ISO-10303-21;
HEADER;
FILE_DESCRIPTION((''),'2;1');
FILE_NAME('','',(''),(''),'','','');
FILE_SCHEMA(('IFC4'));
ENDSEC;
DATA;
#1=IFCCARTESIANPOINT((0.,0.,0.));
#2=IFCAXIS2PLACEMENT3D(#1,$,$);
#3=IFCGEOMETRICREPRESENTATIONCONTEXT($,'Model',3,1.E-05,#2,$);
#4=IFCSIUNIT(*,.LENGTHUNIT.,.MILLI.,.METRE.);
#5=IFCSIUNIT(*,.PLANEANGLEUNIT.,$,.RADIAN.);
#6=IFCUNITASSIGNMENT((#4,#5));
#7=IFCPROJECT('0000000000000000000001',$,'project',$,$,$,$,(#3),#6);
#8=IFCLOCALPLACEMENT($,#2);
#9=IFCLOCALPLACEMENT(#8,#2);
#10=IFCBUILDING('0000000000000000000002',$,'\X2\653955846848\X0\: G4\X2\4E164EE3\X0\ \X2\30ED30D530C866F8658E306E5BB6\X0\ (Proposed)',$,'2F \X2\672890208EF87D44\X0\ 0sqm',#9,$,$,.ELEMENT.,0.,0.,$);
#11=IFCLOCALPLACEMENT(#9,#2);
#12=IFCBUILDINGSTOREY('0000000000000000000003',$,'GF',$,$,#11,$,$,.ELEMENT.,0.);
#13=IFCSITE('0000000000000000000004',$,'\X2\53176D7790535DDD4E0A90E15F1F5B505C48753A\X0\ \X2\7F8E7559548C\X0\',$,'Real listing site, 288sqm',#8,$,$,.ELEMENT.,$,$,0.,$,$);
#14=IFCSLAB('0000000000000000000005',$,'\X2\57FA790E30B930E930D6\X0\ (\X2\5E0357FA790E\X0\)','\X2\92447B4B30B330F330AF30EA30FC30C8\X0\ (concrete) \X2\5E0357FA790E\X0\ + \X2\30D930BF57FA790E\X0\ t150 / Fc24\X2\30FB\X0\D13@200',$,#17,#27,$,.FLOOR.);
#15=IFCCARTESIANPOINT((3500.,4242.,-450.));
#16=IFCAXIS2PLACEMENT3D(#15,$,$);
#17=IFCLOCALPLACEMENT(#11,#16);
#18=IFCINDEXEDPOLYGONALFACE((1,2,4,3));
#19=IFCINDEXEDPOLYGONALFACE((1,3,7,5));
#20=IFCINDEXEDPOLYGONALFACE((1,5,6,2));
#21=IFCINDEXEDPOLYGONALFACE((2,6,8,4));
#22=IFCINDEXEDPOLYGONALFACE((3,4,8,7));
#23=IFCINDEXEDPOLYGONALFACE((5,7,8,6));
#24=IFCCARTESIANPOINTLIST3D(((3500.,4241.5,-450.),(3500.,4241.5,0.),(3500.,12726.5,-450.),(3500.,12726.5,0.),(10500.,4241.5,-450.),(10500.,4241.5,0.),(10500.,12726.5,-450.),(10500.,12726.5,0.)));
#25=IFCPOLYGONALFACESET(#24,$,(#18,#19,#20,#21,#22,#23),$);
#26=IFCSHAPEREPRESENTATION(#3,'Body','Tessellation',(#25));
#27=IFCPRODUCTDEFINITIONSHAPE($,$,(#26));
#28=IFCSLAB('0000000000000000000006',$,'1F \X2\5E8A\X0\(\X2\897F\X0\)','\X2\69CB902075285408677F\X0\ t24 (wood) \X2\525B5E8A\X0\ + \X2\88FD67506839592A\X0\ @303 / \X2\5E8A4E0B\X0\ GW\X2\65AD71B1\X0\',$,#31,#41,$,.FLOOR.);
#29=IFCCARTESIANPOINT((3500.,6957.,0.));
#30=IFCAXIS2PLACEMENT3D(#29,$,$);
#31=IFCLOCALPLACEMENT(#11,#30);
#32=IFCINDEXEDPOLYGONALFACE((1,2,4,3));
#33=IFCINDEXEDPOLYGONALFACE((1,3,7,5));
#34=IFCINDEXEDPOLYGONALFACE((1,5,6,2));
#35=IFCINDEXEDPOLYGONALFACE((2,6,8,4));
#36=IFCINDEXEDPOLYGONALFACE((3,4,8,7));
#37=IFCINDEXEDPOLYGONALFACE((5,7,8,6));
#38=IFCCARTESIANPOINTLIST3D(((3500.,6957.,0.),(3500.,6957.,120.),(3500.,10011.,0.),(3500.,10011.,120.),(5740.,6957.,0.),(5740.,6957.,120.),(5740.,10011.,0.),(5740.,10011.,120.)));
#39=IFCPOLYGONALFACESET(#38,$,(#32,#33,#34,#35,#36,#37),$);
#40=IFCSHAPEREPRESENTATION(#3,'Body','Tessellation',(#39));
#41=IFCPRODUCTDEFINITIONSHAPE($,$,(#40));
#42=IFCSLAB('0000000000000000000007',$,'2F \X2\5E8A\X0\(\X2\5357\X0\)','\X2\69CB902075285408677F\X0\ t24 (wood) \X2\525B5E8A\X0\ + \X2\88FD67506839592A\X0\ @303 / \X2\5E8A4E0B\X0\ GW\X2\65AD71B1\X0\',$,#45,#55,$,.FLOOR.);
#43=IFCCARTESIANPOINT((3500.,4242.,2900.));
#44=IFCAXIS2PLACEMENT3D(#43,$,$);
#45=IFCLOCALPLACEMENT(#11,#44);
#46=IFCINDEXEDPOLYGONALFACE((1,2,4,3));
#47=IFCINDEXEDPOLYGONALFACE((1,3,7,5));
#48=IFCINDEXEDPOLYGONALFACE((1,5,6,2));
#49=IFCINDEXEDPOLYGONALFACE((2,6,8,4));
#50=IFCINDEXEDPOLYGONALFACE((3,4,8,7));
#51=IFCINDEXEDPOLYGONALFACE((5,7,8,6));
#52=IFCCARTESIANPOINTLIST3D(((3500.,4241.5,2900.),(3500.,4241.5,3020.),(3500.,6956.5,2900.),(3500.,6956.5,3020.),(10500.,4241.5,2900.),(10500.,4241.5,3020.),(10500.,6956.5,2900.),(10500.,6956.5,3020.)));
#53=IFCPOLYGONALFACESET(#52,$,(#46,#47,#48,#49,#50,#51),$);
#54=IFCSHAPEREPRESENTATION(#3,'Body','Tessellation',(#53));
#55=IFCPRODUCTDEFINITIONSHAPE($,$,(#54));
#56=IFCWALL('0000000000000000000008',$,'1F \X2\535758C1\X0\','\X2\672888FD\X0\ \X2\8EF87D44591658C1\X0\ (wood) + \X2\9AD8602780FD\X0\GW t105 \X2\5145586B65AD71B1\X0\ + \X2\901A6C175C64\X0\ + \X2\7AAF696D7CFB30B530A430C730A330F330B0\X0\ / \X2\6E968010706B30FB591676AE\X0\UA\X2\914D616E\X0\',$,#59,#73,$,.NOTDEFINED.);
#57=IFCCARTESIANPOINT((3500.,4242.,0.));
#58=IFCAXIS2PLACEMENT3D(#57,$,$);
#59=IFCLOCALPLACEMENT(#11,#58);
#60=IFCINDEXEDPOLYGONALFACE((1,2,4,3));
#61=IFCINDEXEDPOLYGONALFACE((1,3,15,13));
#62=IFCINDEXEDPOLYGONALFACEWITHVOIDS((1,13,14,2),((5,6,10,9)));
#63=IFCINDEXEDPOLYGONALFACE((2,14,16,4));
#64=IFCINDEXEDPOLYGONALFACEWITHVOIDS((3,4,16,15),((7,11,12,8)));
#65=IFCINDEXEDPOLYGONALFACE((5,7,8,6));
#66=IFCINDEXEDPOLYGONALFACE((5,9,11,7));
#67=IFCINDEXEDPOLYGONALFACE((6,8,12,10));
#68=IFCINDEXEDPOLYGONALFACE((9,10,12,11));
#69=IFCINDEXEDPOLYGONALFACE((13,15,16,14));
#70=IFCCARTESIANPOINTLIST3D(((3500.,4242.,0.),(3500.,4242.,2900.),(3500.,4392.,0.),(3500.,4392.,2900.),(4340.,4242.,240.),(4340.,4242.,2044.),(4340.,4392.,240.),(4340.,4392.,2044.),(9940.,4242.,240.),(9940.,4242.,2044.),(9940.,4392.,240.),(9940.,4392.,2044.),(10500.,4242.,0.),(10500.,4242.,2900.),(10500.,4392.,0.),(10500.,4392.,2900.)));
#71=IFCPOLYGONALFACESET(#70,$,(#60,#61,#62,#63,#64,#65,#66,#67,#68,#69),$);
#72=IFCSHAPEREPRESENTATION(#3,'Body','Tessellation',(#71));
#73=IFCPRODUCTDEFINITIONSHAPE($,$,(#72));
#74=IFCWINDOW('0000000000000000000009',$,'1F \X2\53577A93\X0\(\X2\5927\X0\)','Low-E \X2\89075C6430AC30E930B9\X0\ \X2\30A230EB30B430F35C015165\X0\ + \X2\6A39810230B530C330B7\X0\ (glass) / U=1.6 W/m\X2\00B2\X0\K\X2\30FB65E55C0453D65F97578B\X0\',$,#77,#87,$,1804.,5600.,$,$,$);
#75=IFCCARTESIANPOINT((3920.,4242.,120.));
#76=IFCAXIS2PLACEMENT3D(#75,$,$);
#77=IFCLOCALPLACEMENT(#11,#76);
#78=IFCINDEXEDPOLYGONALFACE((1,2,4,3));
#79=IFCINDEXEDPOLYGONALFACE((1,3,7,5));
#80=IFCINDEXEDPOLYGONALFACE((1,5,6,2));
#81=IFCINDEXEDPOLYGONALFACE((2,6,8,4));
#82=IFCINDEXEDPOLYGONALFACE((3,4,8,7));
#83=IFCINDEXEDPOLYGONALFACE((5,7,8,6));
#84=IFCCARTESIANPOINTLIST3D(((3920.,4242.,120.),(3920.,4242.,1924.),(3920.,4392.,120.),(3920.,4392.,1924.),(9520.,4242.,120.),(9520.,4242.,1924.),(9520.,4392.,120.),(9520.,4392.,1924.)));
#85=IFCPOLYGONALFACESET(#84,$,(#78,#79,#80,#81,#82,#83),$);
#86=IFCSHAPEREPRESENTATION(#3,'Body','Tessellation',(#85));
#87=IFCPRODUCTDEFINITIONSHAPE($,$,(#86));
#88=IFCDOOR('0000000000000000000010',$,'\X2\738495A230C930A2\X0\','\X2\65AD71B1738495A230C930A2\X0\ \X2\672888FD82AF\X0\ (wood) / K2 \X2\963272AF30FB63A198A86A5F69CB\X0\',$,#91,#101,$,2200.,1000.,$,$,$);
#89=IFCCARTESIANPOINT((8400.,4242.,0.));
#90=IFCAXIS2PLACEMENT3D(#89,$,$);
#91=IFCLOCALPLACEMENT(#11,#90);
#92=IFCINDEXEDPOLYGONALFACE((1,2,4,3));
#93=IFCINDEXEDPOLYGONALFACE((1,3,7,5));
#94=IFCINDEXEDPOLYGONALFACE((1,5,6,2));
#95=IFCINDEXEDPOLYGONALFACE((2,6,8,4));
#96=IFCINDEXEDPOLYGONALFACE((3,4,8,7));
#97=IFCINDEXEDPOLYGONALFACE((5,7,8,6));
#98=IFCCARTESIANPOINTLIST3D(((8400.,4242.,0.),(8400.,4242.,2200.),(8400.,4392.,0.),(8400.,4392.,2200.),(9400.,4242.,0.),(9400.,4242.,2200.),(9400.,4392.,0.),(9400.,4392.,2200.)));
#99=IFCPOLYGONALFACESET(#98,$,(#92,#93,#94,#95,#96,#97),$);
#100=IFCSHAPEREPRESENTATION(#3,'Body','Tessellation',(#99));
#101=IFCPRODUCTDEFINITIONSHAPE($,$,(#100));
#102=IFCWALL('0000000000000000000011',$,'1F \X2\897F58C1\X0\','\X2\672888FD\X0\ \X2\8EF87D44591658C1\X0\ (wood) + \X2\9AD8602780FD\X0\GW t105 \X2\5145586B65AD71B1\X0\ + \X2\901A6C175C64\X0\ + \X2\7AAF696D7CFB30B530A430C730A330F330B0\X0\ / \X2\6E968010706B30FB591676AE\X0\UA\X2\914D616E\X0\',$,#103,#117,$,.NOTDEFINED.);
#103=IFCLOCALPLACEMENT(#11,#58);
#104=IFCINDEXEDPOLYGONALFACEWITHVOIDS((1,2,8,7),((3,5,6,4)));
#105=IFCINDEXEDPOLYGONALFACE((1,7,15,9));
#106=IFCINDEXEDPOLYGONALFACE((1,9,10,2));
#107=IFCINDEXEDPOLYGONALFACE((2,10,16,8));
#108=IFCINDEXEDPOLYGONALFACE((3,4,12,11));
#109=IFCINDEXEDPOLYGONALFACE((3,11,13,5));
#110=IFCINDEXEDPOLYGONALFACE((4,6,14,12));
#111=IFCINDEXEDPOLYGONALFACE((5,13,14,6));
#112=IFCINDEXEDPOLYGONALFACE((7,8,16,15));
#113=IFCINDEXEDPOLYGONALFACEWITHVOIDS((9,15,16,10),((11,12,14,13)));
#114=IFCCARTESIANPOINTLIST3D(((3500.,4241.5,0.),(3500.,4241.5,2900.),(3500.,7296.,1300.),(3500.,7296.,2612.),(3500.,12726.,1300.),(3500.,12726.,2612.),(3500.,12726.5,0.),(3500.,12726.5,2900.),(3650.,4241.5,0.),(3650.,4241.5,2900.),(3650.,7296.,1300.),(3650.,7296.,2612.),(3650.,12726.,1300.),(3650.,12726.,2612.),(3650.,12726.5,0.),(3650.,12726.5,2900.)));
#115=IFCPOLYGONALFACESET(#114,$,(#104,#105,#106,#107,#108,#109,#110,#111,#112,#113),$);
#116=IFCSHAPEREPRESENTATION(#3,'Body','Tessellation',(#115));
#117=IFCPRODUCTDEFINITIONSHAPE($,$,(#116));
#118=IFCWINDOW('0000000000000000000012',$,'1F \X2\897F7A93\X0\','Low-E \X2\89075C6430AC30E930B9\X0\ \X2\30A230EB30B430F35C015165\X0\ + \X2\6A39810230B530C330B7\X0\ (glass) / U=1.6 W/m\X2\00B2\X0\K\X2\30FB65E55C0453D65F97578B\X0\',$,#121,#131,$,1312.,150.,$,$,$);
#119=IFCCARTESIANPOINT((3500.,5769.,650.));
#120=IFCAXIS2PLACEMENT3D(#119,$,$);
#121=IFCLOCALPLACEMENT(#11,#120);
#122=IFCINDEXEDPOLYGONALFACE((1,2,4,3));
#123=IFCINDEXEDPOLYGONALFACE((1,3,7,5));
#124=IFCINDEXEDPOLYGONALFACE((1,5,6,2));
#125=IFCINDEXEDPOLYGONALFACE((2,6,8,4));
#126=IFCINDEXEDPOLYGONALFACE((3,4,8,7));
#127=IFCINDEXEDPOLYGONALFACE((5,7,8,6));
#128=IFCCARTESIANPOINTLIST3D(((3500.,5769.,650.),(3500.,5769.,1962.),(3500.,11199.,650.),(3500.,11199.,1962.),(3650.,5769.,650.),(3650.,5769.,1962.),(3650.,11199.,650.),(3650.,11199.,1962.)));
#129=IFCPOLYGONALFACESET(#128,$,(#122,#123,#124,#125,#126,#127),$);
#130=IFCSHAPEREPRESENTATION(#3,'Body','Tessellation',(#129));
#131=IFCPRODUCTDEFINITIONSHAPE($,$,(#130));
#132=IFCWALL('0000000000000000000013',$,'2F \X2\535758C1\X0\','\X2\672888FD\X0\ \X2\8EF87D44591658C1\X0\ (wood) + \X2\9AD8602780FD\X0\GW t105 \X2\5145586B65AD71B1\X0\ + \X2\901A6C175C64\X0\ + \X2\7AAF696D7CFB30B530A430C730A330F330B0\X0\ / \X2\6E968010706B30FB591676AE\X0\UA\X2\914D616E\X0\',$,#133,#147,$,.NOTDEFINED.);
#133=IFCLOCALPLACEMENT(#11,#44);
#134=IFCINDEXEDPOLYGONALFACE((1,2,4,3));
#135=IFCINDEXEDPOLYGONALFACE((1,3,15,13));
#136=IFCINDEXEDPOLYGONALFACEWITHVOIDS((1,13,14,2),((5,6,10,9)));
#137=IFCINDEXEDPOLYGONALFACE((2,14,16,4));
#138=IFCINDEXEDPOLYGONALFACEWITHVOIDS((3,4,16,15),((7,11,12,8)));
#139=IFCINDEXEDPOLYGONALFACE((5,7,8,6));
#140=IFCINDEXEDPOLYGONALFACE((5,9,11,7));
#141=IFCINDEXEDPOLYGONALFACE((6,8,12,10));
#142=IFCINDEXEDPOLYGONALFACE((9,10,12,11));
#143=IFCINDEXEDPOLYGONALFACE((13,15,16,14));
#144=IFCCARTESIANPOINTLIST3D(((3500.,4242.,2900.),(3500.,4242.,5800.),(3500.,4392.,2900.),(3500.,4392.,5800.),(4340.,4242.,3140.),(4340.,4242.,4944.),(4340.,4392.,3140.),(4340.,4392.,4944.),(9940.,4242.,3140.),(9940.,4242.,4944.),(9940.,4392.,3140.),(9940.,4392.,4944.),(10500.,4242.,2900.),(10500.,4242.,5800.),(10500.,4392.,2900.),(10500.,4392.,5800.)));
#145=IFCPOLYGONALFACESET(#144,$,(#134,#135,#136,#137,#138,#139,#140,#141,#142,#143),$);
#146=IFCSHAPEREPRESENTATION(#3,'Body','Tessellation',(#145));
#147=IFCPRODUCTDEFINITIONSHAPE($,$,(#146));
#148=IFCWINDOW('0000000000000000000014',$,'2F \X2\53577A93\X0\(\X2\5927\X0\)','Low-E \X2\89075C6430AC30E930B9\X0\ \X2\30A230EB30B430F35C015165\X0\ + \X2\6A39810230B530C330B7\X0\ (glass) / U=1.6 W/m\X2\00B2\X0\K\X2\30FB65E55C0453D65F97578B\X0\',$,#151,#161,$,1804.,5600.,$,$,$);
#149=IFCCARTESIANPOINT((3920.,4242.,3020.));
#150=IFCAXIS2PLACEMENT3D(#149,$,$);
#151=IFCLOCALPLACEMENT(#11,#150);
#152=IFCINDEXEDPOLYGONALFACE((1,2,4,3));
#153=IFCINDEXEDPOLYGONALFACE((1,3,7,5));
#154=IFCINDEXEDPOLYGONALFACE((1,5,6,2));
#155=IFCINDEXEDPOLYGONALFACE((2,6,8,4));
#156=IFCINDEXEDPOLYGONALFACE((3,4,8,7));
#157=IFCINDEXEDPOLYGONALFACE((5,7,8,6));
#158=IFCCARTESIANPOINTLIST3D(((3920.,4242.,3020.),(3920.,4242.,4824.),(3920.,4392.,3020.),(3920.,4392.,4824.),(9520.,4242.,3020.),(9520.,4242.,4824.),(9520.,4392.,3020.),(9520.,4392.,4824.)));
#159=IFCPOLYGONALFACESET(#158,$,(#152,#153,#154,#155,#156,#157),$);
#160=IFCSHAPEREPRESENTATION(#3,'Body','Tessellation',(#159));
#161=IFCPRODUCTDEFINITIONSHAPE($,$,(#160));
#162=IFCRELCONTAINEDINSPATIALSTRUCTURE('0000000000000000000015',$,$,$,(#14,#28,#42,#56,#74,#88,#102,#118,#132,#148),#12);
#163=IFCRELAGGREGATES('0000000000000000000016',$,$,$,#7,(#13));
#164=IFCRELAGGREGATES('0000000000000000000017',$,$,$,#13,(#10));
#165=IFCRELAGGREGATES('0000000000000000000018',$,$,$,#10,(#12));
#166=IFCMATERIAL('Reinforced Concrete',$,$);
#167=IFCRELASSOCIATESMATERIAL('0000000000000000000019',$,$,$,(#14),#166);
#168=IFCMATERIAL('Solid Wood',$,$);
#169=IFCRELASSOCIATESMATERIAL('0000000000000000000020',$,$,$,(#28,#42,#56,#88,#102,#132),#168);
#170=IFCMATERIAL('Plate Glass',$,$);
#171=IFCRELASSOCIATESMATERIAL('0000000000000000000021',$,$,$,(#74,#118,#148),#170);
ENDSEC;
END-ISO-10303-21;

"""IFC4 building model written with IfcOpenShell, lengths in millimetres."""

from ifc_helpers import new_model, si_unit, frame, frame_2d, origin, place, context, project, spatial, rectangle, extrude, material, element, fill, save


model = new_model("IFC4")

# Units and contexts
model_context = context("Model", 3, precision=1e-05, world=origin())
ifc_project = project(units=[si_unit("LENGTHUNIT", "METRE", prefix="MILLI"), si_unit("PLANEANGLEUNIT", "RADIAN")], contexts=[model_context])

# Site, building, storey
site_placement = place(None, origin())
site = spatial("IfcSite", under=ifc_project, at=site_placement, Name="北海道川上郡弟子屈町 美留和", ObjectType="Real listing site, 288sqm", CompositionType="ELEMENT", RefElevation=0.0)
building_placement = place(site_placement, origin())
building = spatial("IfcBuilding", under=site, at=building_placement, Name="改善案: G4世代 ロフト書斎の家 (Proposed)", ObjectType="2F 木造軸組 0sqm", CompositionType="ELEMENT", ElevationOfRefHeight=0.0, ElevationOfTerrain=0.0)
storey_placement = place(building_placement, origin())
storey = spatial("IfcBuildingStorey", under=building, at=storey_placement, Name="GF", CompositionType="ELEMENT", Elevation=0.0)

# Slabs
ifc_material_1 = material(Name="Reinforced Concrete")
slab_1_placement = place(storey_placement, frame((3500.0, 4242.0, -450.0)))
element("IfcSlab", 1, at=slab_1_placement, inside=storey, material=ifc_material_1, Name="基礎スラブ (布基礎)", Description="鉄筋コンクリート (concrete) 布基礎 + ベタ基礎 t150 / Fc24・D13@200", PredefinedType="FLOOR", context=model_context, shape_type="SweptSolid", body=[
    extrude(rectangle(XDim=7000.0, YDim=8485.0, at=frame_2d((3500.0, 4242.0))), frame((3500.0, 4242.0, -450.0)), (0.0, 0.0, 1.0), 450.0),
])
ifc_material_2 = material(Name="Solid Wood")
slab_2_placement = place(storey_placement, frame((3500.0, 6957.0, 0.0)))
element("IfcSlab", 2, at=slab_2_placement, inside=storey, material=ifc_material_2, Name="1F 床(西)", Description="構造用合板 t24 (wood) 剛床 + 製材根太 @303 / 床下 GW断熱", PredefinedType="FLOOR", context=model_context, shape_type="SweptSolid", body=[
    extrude(rectangle(XDim=2240.0, YDim=3054.0, at=frame_2d((1120.0, 1527.0))), frame((3500.0, 6957.0, 0.0)), (0.0, 0.0, 1.0), 120.0),
])
slab_3_placement = place(storey_placement, frame((3500.0, 4242.0, 2900.0)))
element("IfcSlab", 3, at=slab_3_placement, inside=storey, material=ifc_material_2, Name="2F 床(南)", Description="構造用合板 t24 (wood) 剛床 + 製材根太 @303 / 床下 GW断熱", PredefinedType="FLOOR", context=model_context, shape_type="SweptSolid", body=[
    extrude(rectangle(XDim=7000.0, YDim=2715.0, at=frame_2d((3500.0, 1357.0))), frame((3500.0, 4242.0, 2900.0)), (0.0, 0.0, 1.0), 120.0),
])

# Wall, openings, window, door
wall_1_placement = place(storey_placement, frame((3500.0, 4242.0, 0.0)))
wall_1 = element("IfcWall", 4, at=wall_1_placement, inside=storey, material=ifc_material_2, Name="1F 南壁", Description="木製 軸組外壁 (wood) + 高性能GW t105 充填断熱 + 通気層 + 窯業系サイディング / 準耐火・外皮UA配慮", PredefinedType="NOTDEFINED", context=model_context, shape_type="SweptSolid", body=[
    extrude(rectangle(XDim=7000.0, YDim=150.0, at=frame_2d((3500.0, 75.0))), frame((3500.0, 4242.0, 0.0)), (0.0, 0.0, 1.0), 2900.0),
])
opening_1_placement = place(storey_placement, frame((3920.0, 4242.0, 120.0)))
opening_1 = element("IfcOpeningElement", 5, at=opening_1_placement, cuts=wall_1, PredefinedType="NOTDEFINED", context=model_context, shape_type="SweptSolid", body=[
    extrude(rectangle(XDim=5600.0, YDim=150.0, at=frame_2d((2800.0, 75.0))), frame((3920.0, 4242.0, 120.0)), (0.0, 0.0, 1.0), 1804.0),
])
opening_2_placement = place(storey_placement, frame((8400.0, 4242.0, 0.0)))
opening_2 = element("IfcOpeningElement", 6, at=opening_2_placement, cuts=wall_1, PredefinedType="NOTDEFINED", context=model_context, shape_type="SweptSolid", body=[
    extrude(rectangle(XDim=1000.0, YDim=150.0, at=frame_2d((500.0, 75.0))), frame((8400.0, 4242.0, 0.0)), (0.0, 0.0, 1.0), 2200.0),
])
ifc_material_3 = material(Name="Plate Glass")
window_1_placement = place(storey_placement, frame((3920.0, 4242.0, 120.0)))
window_1 = element("IfcWindow", 7, at=window_1_placement, inside=storey, material=ifc_material_3, Name="1F 南窓(大)", Description="Low-E 複層ガラス アルゴン封入 + 樹脂サッシ (glass) / U=1.6 W/m²K・日射取得型", OverallHeight=1804.0, OverallWidth=5600.0, context=model_context, shape_type="SweptSolid", body=[
    extrude(rectangle(XDim=5600.0, YDim=150.0, at=frame_2d((2800.0, 75.0))), frame((3920.0, 4242.0, 120.0)), (0.0, 0.0, 1.0), 1804.0),
])
fill(opening_1, window_1)
door_placement = place(storey_placement, frame((8400.0, 4242.0, 0.0)))
door = element("IfcDoor", 8, at=door_placement, inside=storey, material=ifc_material_2, Name="玄関ドア", Description="断熱玄関ドア 木製芯 (wood) / K2 防犯・採風機構", OverallHeight=2200.0, OverallWidth=1000.0, context=model_context, shape_type="SweptSolid", body=[
    extrude(rectangle(XDim=1000.0, YDim=150.0, at=frame_2d((500.0, 75.0))), frame((8400.0, 4242.0, 0.0)), (0.0, 0.0, 1.0), 2200.0),
])
fill(opening_2, door)

# Walls, openings, windows
wall_2_placement = place(storey_placement, frame((3500.0, 4242.0, 0.0)))
wall_2 = element("IfcWall", 9, at=wall_2_placement, inside=storey, material=ifc_material_2, Name="1F 西壁", Description="木製 軸組外壁 (wood) + 高性能GW t105 充填断熱 + 通気層 + 窯業系サイディング / 準耐火・外皮UA配慮", PredefinedType="NOTDEFINED", context=model_context, shape_type="SweptSolid", body=[
    extrude(rectangle(XDim=150.0, YDim=8485.0, at=frame_2d((75.0, 4242.0))), frame((3500.0, 4242.0, 0.0)), (0.0, 0.0, 1.0), 2900.0),
])
opening_3_placement = place(storey_placement, frame((3500.0, 5769.0, 650.0)))
opening_3 = element("IfcOpeningElement", 10, at=opening_3_placement, cuts=wall_2, PredefinedType="NOTDEFINED", context=model_context, shape_type="SweptSolid", body=[
    extrude(rectangle(XDim=150.0, YDim=5430.0, at=frame_2d((75.0, 2715.0))), frame((3500.0, 5769.0, 650.0)), (0.0, 0.0, 1.0), 1312.0),
])
window_2_placement = place(storey_placement, frame((3500.0, 5769.0, 650.0)))
window_2 = element("IfcWindow", 11, at=window_2_placement, inside=storey, material=ifc_material_3, Name="1F 西窓", Description="Low-E 複層ガラス アルゴン封入 + 樹脂サッシ (glass) / U=1.6 W/m²K・日射取得型", OverallHeight=1312.0, OverallWidth=150.0, context=model_context, shape_type="SweptSolid", body=[
    extrude(rectangle(XDim=150.0, YDim=5430.0, at=frame_2d((75.0, 2715.0))), frame((3500.0, 5769.0, 650.0)), (0.0, 0.0, 1.0), 1312.0),
])
fill(opening_3, window_2)
wall_3_placement = place(storey_placement, frame((3500.0, 4242.0, 2900.0)))
wall_3 = element("IfcWall", 12, at=wall_3_placement, inside=storey, material=ifc_material_2, Name="2F 南壁", Description="木製 軸組外壁 (wood) + 高性能GW t105 充填断熱 + 通気層 + 窯業系サイディング / 準耐火・外皮UA配慮", PredefinedType="NOTDEFINED", context=model_context, shape_type="SweptSolid", body=[
    extrude(rectangle(XDim=7000.0, YDim=150.0, at=frame_2d((3500.0, 75.0))), frame((3500.0, 4242.0, 2900.0)), (0.0, 0.0, 1.0), 2900.0),
])
opening_4_placement = place(storey_placement, frame((3920.0, 4242.0, 3020.0)))
opening_4 = element("IfcOpeningElement", 13, at=opening_4_placement, cuts=wall_3, PredefinedType="NOTDEFINED", context=model_context, shape_type="SweptSolid", body=[
    extrude(rectangle(XDim=5600.0, YDim=150.0, at=frame_2d((2800.0, 75.0))), frame((3920.0, 4242.0, 3020.0)), (0.0, 0.0, 1.0), 1804.0),
])
window_3_placement = place(storey_placement, frame((3920.0, 4242.0, 3020.0)))
window_3 = element("IfcWindow", 14, at=window_3_placement, inside=storey, material=ifc_material_3, Name="2F 南窓(大)", Description="Low-E 複層ガラス アルゴン封入 + 樹脂サッシ (glass) / U=1.6 W/m²K・日射取得型", OverallHeight=1804.0, OverallWidth=5600.0, context=model_context, shape_type="SweptSolid", body=[
    extrude(rectangle(XDim=5600.0, YDim=150.0, at=frame_2d((2800.0, 75.0))), frame((3920.0, 4242.0, 3020.0)), (0.0, 0.0, 1.0), 1804.0),
])
fill(opening_4, window_3)

save(model, "model.ifc")
